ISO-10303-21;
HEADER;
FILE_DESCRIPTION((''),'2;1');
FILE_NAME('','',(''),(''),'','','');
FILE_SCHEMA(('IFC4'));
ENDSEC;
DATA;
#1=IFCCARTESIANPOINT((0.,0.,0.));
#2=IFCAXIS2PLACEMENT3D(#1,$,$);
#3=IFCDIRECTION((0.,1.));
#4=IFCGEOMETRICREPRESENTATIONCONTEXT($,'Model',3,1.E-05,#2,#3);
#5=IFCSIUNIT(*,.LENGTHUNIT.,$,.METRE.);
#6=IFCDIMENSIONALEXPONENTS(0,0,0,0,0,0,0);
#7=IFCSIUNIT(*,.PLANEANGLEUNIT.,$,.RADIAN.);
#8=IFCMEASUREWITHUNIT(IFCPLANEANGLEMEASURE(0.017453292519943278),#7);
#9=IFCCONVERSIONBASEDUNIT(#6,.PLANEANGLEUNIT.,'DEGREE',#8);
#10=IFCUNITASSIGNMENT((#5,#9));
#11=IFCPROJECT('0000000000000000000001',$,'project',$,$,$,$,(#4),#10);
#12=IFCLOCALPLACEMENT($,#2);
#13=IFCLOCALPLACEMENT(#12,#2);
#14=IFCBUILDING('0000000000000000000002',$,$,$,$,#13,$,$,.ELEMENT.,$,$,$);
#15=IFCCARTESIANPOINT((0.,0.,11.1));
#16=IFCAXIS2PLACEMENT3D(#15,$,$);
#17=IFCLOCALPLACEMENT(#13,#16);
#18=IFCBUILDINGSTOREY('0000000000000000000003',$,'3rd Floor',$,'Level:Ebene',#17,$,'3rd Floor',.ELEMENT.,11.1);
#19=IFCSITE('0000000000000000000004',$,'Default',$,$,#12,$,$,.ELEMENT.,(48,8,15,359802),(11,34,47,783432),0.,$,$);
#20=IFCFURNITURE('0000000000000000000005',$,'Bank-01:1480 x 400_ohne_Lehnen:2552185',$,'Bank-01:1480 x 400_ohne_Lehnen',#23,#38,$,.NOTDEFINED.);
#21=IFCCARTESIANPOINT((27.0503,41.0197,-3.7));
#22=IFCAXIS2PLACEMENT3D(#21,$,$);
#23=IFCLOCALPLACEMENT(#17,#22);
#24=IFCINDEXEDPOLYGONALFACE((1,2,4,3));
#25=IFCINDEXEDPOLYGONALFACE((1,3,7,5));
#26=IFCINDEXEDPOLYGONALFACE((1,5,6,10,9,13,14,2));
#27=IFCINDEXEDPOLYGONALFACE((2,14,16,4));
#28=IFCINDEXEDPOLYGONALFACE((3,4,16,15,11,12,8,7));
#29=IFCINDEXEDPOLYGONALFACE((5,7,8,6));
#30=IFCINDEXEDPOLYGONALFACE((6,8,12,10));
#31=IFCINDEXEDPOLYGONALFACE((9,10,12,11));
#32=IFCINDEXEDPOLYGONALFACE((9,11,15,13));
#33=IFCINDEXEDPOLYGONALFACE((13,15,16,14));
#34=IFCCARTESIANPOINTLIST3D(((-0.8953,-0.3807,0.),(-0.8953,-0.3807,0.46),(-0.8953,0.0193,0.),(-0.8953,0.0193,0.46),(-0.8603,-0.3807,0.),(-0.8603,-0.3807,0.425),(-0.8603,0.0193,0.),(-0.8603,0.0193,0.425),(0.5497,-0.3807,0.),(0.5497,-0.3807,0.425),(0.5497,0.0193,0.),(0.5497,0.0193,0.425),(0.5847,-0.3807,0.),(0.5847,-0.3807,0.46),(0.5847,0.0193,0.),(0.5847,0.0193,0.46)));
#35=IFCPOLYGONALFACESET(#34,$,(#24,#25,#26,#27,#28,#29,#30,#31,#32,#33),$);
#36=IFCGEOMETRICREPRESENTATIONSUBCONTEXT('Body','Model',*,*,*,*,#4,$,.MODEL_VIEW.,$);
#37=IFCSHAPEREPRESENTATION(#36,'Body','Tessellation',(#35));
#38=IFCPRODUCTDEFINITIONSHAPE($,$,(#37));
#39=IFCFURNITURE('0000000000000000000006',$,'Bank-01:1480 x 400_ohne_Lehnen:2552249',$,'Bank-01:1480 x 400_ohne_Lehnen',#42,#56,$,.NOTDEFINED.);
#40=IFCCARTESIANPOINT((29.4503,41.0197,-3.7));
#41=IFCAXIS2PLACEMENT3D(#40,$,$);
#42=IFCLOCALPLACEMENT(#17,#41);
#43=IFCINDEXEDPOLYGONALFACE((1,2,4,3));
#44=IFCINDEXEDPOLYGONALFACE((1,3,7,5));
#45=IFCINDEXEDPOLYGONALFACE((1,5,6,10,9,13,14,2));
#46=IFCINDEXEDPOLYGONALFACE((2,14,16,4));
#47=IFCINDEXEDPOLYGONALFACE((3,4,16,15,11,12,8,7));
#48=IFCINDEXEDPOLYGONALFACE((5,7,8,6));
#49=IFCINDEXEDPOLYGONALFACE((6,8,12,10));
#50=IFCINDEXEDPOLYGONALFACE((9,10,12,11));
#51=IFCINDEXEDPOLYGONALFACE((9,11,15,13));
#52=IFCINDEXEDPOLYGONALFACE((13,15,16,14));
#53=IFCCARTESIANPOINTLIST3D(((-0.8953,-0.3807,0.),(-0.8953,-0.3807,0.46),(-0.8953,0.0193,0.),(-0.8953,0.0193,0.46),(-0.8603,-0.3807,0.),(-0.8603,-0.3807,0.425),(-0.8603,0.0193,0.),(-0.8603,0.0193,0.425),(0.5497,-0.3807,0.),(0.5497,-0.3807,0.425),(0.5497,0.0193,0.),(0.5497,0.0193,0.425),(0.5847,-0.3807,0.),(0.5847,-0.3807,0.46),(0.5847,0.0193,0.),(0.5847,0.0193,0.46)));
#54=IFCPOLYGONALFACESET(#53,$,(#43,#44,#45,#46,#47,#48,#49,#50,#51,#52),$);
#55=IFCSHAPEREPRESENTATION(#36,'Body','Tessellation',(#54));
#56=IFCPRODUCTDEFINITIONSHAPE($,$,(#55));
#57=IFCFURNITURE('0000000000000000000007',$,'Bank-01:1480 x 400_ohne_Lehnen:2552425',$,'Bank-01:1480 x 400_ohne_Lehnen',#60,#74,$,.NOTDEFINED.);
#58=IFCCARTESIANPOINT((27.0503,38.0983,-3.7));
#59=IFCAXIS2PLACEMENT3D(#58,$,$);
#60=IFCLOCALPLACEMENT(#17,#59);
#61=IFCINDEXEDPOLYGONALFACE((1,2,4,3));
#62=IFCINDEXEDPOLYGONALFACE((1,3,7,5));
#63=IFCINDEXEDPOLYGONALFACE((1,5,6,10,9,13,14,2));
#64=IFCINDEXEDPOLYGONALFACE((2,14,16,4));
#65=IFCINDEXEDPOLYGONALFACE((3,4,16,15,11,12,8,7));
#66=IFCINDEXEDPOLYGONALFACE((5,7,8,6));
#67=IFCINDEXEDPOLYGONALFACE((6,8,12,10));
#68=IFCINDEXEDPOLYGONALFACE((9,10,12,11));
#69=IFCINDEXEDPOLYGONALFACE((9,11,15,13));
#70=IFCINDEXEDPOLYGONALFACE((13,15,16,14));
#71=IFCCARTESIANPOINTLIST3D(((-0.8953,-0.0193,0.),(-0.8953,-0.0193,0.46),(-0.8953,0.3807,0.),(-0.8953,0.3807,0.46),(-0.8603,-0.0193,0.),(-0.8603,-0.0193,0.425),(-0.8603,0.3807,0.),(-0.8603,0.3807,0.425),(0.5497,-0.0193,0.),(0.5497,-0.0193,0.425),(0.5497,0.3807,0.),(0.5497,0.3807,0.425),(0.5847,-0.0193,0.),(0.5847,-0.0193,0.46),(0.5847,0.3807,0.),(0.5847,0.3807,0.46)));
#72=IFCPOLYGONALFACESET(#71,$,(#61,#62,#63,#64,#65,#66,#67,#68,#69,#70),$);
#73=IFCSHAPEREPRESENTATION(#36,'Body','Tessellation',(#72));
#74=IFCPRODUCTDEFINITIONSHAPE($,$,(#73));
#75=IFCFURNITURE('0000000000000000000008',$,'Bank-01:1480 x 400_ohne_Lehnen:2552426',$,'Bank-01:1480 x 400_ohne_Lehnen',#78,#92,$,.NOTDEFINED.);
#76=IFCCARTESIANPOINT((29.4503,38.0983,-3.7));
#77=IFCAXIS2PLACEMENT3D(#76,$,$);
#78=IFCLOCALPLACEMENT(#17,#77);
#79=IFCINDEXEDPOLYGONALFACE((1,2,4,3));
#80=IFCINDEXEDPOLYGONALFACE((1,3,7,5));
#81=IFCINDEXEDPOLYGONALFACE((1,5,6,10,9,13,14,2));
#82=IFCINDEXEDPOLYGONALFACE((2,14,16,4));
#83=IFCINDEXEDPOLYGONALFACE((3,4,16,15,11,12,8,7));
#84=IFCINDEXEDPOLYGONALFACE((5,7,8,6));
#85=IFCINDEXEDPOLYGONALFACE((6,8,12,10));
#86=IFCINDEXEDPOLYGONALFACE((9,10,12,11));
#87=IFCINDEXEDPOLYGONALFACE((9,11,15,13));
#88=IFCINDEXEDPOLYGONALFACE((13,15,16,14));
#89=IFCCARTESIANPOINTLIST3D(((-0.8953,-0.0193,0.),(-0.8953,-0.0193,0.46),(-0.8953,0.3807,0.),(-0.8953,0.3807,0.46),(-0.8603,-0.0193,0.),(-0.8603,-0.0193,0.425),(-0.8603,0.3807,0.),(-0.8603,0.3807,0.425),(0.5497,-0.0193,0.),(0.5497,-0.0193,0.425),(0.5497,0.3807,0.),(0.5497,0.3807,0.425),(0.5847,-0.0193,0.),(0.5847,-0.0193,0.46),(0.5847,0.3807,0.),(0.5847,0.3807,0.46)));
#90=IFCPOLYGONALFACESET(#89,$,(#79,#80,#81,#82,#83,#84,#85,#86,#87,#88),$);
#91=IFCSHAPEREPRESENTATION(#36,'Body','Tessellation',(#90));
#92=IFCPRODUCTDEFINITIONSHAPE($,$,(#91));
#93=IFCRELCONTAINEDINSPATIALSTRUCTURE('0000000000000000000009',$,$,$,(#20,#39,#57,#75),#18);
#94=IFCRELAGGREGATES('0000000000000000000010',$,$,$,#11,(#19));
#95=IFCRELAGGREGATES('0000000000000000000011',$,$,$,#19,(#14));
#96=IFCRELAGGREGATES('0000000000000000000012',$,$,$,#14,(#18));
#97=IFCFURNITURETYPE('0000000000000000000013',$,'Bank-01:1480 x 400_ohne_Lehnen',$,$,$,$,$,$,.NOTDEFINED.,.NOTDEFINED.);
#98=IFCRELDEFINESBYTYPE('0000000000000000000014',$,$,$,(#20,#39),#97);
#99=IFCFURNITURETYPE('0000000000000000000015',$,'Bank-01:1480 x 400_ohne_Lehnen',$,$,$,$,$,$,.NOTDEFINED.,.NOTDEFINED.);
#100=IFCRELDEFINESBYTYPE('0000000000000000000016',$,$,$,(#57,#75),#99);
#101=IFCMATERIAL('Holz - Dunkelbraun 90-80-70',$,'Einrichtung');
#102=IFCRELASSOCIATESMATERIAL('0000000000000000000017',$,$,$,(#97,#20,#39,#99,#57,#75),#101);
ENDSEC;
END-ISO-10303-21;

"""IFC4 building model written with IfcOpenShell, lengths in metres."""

from ifc_helpers import new_model, entity, si_unit, converted_unit, direction, frame, origin, place, context, subcontext, project, spatial, indexed_curve, outline, extrude, source, transform, mapped, material, type_object, type_shapes, element, save


model = new_model("IFC4")

# Units and contexts
model_context = context("Model", 3, precision=1e-05, world=origin(), true_north=direction((0.0, 1.0)))
body_context = subcontext(model_context, "Body", "Model", "MODEL_VIEW")
ifc_project = project(units=[si_unit("LENGTHUNIT", "METRE"), converted_unit("PLANEANGLEUNIT", "DEGREE", entity("IfcPlaneAngleMeasure", 0.017453292519943278), si_unit("PLANEANGLEUNIT", "RADIAN"), dimensions=[0, 0, 0, 0, 0, 0, 0])], contexts=[model_context])

# Site, building, storey
site_placement = place(None, origin())
site = spatial("IfcSite", under=ifc_project, at=site_placement, Name="Default", CompositionType="ELEMENT", RefLatitude=(48, 8, 15, 359802), RefLongitude=(11, 34, 47, 783432), RefElevation=0.0)
building_placement = place(site_placement, origin())
building = spatial("IfcBuilding", under=site, at=building_placement, CompositionType="ELEMENT")
storey_placement = place(building_placement, frame((0.0, 0.0, 11.1)))
storey = spatial("IfcBuildingStorey", under=building, at=storey_placement, Name="3rd Floor", ObjectType="Level:Ebene", LongName="3rd Floor", CompositionType="ELEMENT", Elevation=11.1)

# Furniture
ifc_material_1 = material(Name="Holz - Dunkelbraun 90-80-70", Category="Einrichtung")
furniture_type_1 = type_object("IfcFurnitureType", Name="Bank-01:1480 x 400_ohne_Lehnen", AssemblyPlace="NOTDEFINED", PredefinedType="NOTDEFINED", material=ifc_material_1)
shared_shape_1 = source(origin(), body_context, "Body", "SweptSolid", [
    extrude(outline(indexed_curve([(-0.74, -0.2387), (0.74, -0.2387), (0.74, 0.2213), (0.705, 0.2213), (0.705, -0.2038), (-0.705, -0.2038), (-0.705, 0.2213), (-0.74, 0.2213), (-0.74, -0.2387)], self_intersect=False)), frame((-0.1553, -0.3807, 0.2213), z_axis=(0.0, 1.0, 0.0), x_axis=(1.0, 0.0, 0.0)), (0.0, 0.0, 1.0), 0.4),
])
type_shapes(furniture_type_1, [shared_shape_1])
for number, where, name in (
    (1, (27.0503, 41.0197, -3.7), "Bank-01:1480 x 400_ohne_Lehnen:2552185"),
    (2, (29.4503, 41.0197, -3.7), "Bank-01:1480 x 400_ohne_Lehnen:2552249"),
):
    element("IfcFurniture", number, at=place(storey_placement, frame(where)), inside=storey, type_object=furniture_type_1, material=ifc_material_1, Name=name, ObjectType="Bank-01:1480 x 400_ohne_Lehnen", PredefinedType="NOTDEFINED", context=body_context, shape_type="MappedRepresentation", body=[
        mapped(shared_shape_1, transform((0.0, 0.0, 0.0), scale=1.0)),
    ])
furniture_type_2 = type_object("IfcFurnitureType", Name="Bank-01:1480 x 400_ohne_Lehnen", AssemblyPlace="NOTDEFINED", PredefinedType="NOTDEFINED", material=ifc_material_1)
shared_shape_2 = source(origin(), body_context, "Body", "SweptSolid", [
    extrude(outline(indexed_curve([(-0.74, -0.2387), (0.74, -0.2387), (0.74, 0.2213), (0.705, 0.2213), (0.705, -0.2038), (-0.705, -0.2038), (-0.705, 0.2213), (-0.74, 0.2213), (-0.74, -0.2387)], self_intersect=False)), frame((-0.1553, -0.0193, 0.2213), z_axis=(0.0, 1.0, 0.0), x_axis=(1.0, 0.0, 0.0)), (0.0, 0.0, 1.0), 0.4),
])
type_shapes(furniture_type_2, [shared_shape_2])
for number, where, name in (
    (3, (27.0503, 38.0983, -3.7), "Bank-01:1480 x 400_ohne_Lehnen:2552425"),
    (4, (29.4503, 38.0983, -3.7), "Bank-01:1480 x 400_ohne_Lehnen:2552426"),
):
    element("IfcFurniture", number, at=place(storey_placement, frame(where)), inside=storey, type_object=furniture_type_2, material=ifc_material_1, Name=name, ObjectType="Bank-01:1480 x 400_ohne_Lehnen", PredefinedType="NOTDEFINED", context=body_context, shape_type="MappedRepresentation", body=[
        mapped(shared_shape_2, transform((0.0, 0.0, 0.0), scale=1.0)),
    ])

save(model, "model.ifc")
